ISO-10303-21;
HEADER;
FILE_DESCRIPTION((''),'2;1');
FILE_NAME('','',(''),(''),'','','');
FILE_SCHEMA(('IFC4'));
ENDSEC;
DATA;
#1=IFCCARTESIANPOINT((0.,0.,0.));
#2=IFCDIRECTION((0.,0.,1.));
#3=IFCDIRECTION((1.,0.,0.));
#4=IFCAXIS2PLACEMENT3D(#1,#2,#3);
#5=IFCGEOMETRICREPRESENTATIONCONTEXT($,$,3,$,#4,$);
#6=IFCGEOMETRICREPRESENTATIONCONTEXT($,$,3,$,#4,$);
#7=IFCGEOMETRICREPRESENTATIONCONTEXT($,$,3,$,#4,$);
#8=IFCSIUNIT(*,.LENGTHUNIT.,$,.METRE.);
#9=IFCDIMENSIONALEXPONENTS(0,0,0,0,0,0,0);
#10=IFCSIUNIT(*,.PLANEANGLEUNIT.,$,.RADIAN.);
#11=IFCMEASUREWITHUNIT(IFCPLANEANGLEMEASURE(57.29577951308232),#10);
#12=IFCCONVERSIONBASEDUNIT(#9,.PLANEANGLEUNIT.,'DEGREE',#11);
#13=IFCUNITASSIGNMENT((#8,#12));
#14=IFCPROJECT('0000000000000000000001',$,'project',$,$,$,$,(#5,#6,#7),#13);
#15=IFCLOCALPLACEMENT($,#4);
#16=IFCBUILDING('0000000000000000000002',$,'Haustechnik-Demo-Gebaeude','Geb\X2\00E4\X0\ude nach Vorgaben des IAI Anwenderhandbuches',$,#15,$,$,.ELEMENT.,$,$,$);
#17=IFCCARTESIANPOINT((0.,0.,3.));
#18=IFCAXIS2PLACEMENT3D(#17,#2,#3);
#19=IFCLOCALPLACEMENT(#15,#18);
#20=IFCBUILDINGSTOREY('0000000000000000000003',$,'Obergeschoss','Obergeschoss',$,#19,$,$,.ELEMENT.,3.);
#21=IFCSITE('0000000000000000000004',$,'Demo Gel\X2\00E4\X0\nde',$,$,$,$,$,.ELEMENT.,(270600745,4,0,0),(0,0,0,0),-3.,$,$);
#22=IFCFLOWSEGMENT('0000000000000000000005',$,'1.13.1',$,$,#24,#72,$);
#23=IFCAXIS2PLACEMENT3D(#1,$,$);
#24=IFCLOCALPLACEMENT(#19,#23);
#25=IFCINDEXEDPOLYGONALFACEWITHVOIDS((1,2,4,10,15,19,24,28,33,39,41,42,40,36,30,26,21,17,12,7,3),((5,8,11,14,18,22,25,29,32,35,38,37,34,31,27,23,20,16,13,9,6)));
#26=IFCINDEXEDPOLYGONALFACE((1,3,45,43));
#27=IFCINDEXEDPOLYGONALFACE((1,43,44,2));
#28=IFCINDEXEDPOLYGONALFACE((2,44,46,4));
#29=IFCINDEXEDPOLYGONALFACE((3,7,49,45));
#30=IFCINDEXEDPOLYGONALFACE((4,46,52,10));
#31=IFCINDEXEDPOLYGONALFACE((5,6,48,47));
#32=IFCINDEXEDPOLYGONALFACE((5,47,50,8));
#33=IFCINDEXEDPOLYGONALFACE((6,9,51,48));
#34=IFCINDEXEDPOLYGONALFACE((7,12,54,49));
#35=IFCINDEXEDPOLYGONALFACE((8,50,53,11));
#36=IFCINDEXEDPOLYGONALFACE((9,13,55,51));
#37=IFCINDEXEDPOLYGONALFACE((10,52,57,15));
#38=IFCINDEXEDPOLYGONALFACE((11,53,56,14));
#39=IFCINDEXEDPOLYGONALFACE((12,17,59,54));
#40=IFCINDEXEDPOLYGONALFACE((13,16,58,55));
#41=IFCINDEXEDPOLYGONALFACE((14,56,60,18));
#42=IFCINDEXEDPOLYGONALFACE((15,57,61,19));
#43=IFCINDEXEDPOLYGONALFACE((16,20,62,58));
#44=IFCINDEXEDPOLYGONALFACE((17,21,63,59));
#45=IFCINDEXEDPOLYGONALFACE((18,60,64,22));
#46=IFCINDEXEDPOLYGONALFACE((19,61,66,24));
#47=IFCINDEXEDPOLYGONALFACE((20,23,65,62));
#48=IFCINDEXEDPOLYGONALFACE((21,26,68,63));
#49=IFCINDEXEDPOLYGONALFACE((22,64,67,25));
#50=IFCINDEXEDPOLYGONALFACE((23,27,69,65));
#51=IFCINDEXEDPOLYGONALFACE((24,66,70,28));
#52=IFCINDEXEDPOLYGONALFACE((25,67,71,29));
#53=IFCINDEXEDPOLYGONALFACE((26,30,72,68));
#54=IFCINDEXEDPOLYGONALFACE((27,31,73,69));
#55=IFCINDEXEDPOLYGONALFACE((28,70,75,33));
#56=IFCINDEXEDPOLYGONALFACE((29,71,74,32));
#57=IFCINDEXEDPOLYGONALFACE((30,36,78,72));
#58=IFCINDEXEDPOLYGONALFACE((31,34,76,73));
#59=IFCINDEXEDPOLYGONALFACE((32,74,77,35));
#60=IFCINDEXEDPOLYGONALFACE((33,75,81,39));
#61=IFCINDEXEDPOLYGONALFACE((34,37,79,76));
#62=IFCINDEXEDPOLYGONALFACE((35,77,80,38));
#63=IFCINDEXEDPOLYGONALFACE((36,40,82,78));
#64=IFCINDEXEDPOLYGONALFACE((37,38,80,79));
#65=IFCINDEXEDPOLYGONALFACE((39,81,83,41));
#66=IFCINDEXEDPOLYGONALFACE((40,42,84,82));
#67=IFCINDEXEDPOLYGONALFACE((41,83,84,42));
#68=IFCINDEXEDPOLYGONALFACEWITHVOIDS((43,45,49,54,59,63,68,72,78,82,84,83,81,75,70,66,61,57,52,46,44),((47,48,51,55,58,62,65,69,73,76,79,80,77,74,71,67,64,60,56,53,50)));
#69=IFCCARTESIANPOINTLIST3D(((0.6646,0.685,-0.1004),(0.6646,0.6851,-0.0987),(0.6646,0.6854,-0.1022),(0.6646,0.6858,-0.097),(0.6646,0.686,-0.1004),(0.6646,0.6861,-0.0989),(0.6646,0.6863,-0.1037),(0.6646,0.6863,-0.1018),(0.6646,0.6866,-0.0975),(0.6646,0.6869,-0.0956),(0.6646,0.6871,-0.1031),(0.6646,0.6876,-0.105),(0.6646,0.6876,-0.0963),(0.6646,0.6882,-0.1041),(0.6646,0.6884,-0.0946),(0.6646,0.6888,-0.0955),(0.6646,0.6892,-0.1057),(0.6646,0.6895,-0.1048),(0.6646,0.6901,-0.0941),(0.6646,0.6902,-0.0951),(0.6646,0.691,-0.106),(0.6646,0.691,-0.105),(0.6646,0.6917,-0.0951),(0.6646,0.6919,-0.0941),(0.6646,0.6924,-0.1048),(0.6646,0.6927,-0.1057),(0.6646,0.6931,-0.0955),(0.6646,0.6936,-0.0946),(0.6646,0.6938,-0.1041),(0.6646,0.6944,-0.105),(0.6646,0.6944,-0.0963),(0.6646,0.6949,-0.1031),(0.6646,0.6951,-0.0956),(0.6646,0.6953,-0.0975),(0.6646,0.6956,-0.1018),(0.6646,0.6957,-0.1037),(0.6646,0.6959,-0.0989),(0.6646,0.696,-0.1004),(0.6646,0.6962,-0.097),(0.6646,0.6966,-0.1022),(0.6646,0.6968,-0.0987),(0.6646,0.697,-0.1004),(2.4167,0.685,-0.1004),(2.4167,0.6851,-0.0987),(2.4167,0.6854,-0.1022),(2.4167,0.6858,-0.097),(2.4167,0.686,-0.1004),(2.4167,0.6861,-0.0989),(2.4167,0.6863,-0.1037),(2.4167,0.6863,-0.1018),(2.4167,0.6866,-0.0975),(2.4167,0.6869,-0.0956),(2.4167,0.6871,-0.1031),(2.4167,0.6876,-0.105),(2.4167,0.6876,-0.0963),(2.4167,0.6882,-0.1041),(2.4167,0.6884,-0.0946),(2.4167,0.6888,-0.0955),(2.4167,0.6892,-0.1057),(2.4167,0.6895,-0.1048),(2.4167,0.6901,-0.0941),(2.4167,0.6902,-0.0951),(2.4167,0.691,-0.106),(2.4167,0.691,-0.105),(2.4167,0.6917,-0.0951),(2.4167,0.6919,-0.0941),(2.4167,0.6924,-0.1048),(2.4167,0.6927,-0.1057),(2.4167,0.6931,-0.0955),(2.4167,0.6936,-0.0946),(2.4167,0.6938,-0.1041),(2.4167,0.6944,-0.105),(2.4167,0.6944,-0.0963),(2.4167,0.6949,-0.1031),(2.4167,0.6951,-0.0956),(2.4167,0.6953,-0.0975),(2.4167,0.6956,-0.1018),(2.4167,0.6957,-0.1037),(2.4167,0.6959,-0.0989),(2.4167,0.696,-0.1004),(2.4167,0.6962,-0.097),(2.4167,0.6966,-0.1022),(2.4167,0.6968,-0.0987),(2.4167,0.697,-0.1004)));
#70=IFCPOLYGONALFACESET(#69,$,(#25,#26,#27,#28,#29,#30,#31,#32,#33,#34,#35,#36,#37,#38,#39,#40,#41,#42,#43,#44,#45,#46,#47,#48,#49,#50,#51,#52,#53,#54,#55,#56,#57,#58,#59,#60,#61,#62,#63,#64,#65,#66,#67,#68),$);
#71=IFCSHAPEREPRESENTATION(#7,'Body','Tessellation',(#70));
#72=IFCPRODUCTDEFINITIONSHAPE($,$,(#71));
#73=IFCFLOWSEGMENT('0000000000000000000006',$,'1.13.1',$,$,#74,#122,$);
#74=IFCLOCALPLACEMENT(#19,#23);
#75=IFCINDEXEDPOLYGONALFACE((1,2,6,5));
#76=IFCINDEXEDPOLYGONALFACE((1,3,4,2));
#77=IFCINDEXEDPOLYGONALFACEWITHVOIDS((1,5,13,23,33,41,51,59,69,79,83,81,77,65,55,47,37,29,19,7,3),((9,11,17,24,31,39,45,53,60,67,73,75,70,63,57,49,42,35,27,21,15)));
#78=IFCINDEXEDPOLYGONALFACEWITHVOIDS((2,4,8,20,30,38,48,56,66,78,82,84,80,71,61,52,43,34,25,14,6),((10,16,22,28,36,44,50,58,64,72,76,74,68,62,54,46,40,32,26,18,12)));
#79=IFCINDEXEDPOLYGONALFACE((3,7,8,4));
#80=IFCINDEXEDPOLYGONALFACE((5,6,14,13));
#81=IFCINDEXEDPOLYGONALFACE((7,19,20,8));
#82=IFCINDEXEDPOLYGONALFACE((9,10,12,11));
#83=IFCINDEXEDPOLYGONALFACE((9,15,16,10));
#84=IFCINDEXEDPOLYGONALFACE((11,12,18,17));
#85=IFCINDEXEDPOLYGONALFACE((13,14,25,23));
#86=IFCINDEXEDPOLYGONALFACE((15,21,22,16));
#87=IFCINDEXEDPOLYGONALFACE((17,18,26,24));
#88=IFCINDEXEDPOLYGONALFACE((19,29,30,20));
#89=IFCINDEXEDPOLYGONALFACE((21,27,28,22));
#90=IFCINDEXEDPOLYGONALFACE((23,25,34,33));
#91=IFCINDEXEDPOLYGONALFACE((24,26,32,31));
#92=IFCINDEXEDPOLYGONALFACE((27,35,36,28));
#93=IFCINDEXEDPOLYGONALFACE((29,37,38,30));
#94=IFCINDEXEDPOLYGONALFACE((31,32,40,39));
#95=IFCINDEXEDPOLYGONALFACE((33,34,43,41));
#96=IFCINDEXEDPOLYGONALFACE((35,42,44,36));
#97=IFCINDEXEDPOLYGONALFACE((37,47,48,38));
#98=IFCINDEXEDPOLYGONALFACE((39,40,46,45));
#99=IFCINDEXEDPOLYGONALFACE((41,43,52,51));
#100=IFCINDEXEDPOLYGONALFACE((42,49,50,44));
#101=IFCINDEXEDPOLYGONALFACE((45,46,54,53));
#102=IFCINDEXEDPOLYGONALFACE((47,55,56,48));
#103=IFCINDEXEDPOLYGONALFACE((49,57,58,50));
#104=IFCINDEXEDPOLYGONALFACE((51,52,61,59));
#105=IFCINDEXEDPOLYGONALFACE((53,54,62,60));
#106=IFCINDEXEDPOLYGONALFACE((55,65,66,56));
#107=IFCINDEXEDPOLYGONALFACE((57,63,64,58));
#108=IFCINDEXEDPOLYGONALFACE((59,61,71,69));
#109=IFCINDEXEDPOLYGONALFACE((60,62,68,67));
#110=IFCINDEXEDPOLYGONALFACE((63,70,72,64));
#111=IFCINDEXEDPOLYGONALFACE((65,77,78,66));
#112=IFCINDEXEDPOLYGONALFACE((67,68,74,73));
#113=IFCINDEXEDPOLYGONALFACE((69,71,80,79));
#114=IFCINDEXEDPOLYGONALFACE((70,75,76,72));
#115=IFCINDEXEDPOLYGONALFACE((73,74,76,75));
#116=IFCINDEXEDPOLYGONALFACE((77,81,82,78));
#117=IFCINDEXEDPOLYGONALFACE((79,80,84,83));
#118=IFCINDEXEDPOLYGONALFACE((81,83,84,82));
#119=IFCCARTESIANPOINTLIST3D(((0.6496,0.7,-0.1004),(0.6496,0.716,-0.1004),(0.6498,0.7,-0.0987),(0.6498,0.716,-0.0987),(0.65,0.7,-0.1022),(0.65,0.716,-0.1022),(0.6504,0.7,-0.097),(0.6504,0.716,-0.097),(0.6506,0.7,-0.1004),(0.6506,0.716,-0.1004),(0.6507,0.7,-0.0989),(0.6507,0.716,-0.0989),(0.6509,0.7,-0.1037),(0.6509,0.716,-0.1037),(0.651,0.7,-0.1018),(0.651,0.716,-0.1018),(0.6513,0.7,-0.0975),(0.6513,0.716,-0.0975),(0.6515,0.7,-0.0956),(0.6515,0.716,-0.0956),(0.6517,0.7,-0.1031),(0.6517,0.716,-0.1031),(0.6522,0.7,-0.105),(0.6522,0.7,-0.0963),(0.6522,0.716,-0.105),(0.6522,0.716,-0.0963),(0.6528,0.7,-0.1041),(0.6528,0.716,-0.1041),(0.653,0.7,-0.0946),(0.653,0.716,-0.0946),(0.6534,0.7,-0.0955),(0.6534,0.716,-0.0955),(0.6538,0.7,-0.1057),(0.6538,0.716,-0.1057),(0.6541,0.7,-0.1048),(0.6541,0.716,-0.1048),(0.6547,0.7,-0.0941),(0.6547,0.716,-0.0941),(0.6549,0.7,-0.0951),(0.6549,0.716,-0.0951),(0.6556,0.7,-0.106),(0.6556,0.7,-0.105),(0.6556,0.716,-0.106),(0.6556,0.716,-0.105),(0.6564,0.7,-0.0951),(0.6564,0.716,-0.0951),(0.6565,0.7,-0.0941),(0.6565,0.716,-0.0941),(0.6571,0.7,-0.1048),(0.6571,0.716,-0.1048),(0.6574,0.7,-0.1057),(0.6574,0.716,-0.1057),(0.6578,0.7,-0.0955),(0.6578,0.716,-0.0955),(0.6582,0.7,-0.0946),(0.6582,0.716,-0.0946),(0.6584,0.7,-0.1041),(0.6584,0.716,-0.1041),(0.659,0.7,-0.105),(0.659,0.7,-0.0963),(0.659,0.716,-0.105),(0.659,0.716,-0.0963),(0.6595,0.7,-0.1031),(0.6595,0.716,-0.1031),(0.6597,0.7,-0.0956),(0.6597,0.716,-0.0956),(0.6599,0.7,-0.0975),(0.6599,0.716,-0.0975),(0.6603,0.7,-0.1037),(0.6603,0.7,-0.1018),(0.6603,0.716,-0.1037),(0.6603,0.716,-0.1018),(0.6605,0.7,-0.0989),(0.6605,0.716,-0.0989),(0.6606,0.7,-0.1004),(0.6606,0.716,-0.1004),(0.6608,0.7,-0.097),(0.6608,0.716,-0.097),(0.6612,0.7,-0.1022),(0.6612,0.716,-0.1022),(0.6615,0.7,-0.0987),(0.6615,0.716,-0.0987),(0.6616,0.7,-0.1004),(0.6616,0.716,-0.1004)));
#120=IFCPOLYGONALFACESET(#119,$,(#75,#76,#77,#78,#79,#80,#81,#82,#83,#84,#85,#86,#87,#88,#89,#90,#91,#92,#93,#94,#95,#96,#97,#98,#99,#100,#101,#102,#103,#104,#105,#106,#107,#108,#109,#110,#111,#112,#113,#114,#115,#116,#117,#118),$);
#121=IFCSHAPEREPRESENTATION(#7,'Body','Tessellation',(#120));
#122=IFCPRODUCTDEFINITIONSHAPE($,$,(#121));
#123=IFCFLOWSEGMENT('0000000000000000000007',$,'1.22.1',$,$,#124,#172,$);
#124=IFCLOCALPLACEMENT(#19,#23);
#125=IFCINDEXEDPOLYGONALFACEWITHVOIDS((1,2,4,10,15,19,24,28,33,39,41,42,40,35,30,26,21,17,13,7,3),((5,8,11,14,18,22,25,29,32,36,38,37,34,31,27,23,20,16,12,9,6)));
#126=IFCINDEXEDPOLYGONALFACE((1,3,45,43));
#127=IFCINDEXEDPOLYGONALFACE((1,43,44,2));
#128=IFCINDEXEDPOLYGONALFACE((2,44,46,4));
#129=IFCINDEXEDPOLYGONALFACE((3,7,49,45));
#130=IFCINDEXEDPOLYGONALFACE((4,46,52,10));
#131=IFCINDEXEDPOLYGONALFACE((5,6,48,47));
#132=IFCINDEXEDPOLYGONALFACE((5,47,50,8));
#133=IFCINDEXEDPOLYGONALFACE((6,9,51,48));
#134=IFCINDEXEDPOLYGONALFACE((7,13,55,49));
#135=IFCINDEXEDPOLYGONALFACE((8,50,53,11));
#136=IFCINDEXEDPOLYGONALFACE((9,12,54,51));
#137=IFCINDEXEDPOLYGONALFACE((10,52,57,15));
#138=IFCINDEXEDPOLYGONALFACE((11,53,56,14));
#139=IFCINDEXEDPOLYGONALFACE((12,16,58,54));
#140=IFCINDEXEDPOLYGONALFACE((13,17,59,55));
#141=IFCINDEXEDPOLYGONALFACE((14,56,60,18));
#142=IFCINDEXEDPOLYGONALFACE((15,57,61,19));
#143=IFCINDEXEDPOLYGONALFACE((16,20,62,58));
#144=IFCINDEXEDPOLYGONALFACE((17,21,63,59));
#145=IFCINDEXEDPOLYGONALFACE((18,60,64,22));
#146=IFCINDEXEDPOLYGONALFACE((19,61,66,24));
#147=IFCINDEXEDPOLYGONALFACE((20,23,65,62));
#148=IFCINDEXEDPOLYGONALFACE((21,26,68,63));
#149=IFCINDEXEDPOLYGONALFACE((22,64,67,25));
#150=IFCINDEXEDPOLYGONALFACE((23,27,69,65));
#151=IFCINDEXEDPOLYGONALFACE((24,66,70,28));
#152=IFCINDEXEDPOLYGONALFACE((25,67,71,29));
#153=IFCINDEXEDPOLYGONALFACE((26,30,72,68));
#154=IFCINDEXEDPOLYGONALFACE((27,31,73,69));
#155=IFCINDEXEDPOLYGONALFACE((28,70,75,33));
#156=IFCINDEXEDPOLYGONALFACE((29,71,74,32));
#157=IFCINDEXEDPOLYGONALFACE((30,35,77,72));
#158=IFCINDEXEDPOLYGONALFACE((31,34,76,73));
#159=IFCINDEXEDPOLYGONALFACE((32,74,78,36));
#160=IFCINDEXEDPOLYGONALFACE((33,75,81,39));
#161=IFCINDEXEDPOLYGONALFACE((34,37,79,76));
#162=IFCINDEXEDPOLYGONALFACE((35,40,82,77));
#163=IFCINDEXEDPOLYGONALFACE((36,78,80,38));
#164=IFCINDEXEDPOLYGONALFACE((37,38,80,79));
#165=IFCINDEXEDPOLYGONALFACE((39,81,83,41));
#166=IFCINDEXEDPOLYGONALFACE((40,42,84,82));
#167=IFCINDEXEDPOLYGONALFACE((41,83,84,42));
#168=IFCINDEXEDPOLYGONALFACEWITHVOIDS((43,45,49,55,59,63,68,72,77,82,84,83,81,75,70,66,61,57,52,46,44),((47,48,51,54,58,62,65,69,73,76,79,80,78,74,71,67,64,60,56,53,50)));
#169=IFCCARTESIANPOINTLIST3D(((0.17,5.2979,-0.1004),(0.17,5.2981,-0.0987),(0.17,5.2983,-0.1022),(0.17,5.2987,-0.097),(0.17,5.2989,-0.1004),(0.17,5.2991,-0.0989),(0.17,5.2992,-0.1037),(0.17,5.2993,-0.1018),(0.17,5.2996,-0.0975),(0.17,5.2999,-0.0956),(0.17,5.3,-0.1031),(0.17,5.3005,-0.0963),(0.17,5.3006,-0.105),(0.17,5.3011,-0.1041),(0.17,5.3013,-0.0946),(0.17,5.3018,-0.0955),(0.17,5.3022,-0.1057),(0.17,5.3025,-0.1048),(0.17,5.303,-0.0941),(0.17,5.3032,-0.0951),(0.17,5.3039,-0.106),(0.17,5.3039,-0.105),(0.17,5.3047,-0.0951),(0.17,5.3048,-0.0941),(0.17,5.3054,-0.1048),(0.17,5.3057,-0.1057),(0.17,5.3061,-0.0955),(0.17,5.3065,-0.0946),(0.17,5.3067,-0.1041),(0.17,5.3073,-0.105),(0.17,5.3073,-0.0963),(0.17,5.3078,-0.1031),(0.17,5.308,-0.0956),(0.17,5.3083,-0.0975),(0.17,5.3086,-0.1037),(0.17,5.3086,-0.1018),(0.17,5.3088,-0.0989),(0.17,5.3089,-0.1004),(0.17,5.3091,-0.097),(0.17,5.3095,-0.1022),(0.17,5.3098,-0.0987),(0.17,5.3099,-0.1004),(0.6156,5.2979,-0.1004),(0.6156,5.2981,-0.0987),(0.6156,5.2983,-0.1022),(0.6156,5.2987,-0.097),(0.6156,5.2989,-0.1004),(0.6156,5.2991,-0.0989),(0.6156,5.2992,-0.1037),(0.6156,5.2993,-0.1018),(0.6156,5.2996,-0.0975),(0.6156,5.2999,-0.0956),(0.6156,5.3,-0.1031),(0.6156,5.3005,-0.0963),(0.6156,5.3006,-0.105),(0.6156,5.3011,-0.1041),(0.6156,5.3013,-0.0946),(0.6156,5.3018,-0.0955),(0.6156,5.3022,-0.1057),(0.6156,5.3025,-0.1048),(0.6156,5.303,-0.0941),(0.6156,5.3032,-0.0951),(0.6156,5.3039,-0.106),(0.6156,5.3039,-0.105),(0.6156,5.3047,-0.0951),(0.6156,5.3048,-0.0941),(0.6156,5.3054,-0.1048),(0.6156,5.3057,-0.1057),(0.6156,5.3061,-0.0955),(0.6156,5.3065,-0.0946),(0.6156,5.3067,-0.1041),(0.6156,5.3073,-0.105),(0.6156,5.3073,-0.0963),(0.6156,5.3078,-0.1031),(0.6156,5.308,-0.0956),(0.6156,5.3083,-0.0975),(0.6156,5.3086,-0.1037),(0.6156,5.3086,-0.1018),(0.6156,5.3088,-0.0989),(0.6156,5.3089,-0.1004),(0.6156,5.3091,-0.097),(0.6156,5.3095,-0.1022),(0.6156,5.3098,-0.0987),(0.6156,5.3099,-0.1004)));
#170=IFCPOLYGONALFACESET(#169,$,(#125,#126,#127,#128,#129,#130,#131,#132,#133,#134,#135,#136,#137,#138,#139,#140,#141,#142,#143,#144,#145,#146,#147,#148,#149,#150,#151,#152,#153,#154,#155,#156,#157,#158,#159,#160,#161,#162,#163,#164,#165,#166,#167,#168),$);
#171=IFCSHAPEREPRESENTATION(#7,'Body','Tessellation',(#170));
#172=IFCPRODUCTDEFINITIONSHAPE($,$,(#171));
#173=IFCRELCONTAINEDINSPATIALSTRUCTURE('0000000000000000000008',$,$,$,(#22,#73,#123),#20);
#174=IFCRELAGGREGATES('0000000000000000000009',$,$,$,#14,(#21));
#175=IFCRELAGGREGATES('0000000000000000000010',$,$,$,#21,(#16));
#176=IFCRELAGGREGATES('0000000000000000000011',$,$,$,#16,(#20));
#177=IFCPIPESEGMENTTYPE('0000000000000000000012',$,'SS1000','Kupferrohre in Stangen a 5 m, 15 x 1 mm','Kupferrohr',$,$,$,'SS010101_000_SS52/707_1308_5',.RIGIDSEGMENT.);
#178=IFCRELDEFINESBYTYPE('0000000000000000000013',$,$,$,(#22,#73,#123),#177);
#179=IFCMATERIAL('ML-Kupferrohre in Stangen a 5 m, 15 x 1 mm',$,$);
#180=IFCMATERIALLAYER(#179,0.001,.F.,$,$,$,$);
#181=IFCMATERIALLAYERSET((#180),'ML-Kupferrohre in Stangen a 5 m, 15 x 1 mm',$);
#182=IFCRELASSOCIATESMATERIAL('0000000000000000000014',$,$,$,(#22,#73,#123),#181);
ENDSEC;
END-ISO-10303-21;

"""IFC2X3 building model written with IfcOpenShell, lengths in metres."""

from ifc_helpers import new_model, entity, si_unit, converted_unit, frame, origin_with_axes, origin_2d_with_axis, place, context, project, spatial, hollow_circle, extrude, material, layer, layer_set, layer_usage, type_object, element, save


model = new_model("IFC2X3")

# Units and contexts
context_of_model_1 = context(None, 3, world=origin_with_axes())
context_of_model_2 = context(None, 3, world=origin_with_axes())
context_of_model_3 = context(None, 3, world=origin_with_axes())
ifc_project = project(units=[si_unit("LENGTHUNIT", "METRE"), converted_unit("PLANEANGLEUNIT", "DEGREE", entity("IfcPlaneAngleMeasure", 57.29577951308232), si_unit("PLANEANGLEUNIT", "RADIAN"), dimensions=[0, 0, 0, 0, 0, 0, 0])], contexts=[context_of_model_1, context_of_model_2, context_of_model_3])

# Site, building, storey
site = spatial("IfcSite", under=ifc_project, Name="Demo Gelände", CompositionType="ELEMENT", RefLatitude=(270600745, 4, 0, 0), RefLongitude=(0, 0, 0, 0), RefElevation=-3.0)
building_placement = place(None, origin_with_axes())
building = spatial("IfcBuilding", under=site, at=building_placement, Name="Haustechnik-Demo-Gebaeude", Description="Gebäude nach Vorgaben des IAI Anwenderhandbuches", CompositionType="ELEMENT")
storey_placement = place(building_placement, frame((0.0, 0.0, 3.0), z_axis=(0.0, 0.0, 1.0), x_axis=(1.0, 0.0, 0.0)))
storey = spatial("IfcBuildingStorey", under=building, at=storey_placement, Name="Obergeschoss", Description="Obergeschoss", CompositionType="ELEMENT", Elevation=3.0)

# Flow segments
ifc_material = material(Name="ML-Kupferrohre in Stangen a 5 m, 15 x 1 mm")
ifc_layer = layer(ifc_material, 0.001, ventilated=False)
ifc_layer_set = layer_set([ifc_layer], Name="ML-Kupferrohre in Stangen a 5 m, 15 x 1 mm")
ifc_layer_usage = layer_usage(ifc_layer_set, "AXIS2", "POSITIVE", 0.0)
pipe_segment_type_1 = type_object("IfcPipeSegmentType", Name="SS1000", Description="Kupferrohre in Stangen a 5 m, 15 x 1 mm", ApplicableOccurrence="Kupferrohr", ElementType="SS010101_000_SS52/707_1308_5", PredefinedType="RIGIDSEGMENT")
flow_segment_1_placement = place(storey_placement, frame((2.4167, 0.691, -0.1), z_axis=(-1.0, 0.0, 0.0), x_axis=(0.0, 0.0, -1.0)))
element("IfcFlowSegment", 1, at=flow_segment_1_placement, inside=storey, type_object=pipe_segment_type_1, material=ifc_layer_usage, Name="1.13.1", context=context_of_model_3, shape_type="SweptSolid", body=[
    extrude(hollow_circle(Radius=0.006, WallThickness=0.001, at=origin_2d_with_axis()), origin_with_axes(), (0.0, 0.0, 1.0), 1.7521),
])
flow_segment_2_placement = place(storey_placement, frame((0.6556, 0.7, -0.1), z_axis=(0.0, 1.0, 0.0), x_axis=(0.0, 0.0, -1.0)))
element("IfcFlowSegment", 2, at=flow_segment_2_placement, inside=storey, type_object=pipe_segment_type_1, material=ifc_layer_usage, Name="1.13.1", context=context_of_model_3, shape_type="SweptSolid", body=[
    extrude(hollow_circle(Radius=0.006, WallThickness=0.001, at=origin_2d_with_axis()), origin_with_axes(), (0.0, 0.0, 1.0), 0.016),
])
flow_segment_3_placement = place(storey_placement, frame((0.6156, 5.3039, -0.1), z_axis=(-1.0, 0.0, 0.0), x_axis=(0.0, 0.0, -1.0)))
element("IfcFlowSegment", 3, at=flow_segment_3_placement, inside=storey, type_object=pipe_segment_type_1, material=ifc_layer_usage, Name="1.22.1", context=context_of_model_3, shape_type="SweptSolid", body=[
    extrude(hollow_circle(Radius=0.006, WallThickness=0.001, at=origin_2d_with_axis()), origin_with_axes(), (0.0, 0.0, 1.0), 0.4457),
])

save(model, "model.ifc")
